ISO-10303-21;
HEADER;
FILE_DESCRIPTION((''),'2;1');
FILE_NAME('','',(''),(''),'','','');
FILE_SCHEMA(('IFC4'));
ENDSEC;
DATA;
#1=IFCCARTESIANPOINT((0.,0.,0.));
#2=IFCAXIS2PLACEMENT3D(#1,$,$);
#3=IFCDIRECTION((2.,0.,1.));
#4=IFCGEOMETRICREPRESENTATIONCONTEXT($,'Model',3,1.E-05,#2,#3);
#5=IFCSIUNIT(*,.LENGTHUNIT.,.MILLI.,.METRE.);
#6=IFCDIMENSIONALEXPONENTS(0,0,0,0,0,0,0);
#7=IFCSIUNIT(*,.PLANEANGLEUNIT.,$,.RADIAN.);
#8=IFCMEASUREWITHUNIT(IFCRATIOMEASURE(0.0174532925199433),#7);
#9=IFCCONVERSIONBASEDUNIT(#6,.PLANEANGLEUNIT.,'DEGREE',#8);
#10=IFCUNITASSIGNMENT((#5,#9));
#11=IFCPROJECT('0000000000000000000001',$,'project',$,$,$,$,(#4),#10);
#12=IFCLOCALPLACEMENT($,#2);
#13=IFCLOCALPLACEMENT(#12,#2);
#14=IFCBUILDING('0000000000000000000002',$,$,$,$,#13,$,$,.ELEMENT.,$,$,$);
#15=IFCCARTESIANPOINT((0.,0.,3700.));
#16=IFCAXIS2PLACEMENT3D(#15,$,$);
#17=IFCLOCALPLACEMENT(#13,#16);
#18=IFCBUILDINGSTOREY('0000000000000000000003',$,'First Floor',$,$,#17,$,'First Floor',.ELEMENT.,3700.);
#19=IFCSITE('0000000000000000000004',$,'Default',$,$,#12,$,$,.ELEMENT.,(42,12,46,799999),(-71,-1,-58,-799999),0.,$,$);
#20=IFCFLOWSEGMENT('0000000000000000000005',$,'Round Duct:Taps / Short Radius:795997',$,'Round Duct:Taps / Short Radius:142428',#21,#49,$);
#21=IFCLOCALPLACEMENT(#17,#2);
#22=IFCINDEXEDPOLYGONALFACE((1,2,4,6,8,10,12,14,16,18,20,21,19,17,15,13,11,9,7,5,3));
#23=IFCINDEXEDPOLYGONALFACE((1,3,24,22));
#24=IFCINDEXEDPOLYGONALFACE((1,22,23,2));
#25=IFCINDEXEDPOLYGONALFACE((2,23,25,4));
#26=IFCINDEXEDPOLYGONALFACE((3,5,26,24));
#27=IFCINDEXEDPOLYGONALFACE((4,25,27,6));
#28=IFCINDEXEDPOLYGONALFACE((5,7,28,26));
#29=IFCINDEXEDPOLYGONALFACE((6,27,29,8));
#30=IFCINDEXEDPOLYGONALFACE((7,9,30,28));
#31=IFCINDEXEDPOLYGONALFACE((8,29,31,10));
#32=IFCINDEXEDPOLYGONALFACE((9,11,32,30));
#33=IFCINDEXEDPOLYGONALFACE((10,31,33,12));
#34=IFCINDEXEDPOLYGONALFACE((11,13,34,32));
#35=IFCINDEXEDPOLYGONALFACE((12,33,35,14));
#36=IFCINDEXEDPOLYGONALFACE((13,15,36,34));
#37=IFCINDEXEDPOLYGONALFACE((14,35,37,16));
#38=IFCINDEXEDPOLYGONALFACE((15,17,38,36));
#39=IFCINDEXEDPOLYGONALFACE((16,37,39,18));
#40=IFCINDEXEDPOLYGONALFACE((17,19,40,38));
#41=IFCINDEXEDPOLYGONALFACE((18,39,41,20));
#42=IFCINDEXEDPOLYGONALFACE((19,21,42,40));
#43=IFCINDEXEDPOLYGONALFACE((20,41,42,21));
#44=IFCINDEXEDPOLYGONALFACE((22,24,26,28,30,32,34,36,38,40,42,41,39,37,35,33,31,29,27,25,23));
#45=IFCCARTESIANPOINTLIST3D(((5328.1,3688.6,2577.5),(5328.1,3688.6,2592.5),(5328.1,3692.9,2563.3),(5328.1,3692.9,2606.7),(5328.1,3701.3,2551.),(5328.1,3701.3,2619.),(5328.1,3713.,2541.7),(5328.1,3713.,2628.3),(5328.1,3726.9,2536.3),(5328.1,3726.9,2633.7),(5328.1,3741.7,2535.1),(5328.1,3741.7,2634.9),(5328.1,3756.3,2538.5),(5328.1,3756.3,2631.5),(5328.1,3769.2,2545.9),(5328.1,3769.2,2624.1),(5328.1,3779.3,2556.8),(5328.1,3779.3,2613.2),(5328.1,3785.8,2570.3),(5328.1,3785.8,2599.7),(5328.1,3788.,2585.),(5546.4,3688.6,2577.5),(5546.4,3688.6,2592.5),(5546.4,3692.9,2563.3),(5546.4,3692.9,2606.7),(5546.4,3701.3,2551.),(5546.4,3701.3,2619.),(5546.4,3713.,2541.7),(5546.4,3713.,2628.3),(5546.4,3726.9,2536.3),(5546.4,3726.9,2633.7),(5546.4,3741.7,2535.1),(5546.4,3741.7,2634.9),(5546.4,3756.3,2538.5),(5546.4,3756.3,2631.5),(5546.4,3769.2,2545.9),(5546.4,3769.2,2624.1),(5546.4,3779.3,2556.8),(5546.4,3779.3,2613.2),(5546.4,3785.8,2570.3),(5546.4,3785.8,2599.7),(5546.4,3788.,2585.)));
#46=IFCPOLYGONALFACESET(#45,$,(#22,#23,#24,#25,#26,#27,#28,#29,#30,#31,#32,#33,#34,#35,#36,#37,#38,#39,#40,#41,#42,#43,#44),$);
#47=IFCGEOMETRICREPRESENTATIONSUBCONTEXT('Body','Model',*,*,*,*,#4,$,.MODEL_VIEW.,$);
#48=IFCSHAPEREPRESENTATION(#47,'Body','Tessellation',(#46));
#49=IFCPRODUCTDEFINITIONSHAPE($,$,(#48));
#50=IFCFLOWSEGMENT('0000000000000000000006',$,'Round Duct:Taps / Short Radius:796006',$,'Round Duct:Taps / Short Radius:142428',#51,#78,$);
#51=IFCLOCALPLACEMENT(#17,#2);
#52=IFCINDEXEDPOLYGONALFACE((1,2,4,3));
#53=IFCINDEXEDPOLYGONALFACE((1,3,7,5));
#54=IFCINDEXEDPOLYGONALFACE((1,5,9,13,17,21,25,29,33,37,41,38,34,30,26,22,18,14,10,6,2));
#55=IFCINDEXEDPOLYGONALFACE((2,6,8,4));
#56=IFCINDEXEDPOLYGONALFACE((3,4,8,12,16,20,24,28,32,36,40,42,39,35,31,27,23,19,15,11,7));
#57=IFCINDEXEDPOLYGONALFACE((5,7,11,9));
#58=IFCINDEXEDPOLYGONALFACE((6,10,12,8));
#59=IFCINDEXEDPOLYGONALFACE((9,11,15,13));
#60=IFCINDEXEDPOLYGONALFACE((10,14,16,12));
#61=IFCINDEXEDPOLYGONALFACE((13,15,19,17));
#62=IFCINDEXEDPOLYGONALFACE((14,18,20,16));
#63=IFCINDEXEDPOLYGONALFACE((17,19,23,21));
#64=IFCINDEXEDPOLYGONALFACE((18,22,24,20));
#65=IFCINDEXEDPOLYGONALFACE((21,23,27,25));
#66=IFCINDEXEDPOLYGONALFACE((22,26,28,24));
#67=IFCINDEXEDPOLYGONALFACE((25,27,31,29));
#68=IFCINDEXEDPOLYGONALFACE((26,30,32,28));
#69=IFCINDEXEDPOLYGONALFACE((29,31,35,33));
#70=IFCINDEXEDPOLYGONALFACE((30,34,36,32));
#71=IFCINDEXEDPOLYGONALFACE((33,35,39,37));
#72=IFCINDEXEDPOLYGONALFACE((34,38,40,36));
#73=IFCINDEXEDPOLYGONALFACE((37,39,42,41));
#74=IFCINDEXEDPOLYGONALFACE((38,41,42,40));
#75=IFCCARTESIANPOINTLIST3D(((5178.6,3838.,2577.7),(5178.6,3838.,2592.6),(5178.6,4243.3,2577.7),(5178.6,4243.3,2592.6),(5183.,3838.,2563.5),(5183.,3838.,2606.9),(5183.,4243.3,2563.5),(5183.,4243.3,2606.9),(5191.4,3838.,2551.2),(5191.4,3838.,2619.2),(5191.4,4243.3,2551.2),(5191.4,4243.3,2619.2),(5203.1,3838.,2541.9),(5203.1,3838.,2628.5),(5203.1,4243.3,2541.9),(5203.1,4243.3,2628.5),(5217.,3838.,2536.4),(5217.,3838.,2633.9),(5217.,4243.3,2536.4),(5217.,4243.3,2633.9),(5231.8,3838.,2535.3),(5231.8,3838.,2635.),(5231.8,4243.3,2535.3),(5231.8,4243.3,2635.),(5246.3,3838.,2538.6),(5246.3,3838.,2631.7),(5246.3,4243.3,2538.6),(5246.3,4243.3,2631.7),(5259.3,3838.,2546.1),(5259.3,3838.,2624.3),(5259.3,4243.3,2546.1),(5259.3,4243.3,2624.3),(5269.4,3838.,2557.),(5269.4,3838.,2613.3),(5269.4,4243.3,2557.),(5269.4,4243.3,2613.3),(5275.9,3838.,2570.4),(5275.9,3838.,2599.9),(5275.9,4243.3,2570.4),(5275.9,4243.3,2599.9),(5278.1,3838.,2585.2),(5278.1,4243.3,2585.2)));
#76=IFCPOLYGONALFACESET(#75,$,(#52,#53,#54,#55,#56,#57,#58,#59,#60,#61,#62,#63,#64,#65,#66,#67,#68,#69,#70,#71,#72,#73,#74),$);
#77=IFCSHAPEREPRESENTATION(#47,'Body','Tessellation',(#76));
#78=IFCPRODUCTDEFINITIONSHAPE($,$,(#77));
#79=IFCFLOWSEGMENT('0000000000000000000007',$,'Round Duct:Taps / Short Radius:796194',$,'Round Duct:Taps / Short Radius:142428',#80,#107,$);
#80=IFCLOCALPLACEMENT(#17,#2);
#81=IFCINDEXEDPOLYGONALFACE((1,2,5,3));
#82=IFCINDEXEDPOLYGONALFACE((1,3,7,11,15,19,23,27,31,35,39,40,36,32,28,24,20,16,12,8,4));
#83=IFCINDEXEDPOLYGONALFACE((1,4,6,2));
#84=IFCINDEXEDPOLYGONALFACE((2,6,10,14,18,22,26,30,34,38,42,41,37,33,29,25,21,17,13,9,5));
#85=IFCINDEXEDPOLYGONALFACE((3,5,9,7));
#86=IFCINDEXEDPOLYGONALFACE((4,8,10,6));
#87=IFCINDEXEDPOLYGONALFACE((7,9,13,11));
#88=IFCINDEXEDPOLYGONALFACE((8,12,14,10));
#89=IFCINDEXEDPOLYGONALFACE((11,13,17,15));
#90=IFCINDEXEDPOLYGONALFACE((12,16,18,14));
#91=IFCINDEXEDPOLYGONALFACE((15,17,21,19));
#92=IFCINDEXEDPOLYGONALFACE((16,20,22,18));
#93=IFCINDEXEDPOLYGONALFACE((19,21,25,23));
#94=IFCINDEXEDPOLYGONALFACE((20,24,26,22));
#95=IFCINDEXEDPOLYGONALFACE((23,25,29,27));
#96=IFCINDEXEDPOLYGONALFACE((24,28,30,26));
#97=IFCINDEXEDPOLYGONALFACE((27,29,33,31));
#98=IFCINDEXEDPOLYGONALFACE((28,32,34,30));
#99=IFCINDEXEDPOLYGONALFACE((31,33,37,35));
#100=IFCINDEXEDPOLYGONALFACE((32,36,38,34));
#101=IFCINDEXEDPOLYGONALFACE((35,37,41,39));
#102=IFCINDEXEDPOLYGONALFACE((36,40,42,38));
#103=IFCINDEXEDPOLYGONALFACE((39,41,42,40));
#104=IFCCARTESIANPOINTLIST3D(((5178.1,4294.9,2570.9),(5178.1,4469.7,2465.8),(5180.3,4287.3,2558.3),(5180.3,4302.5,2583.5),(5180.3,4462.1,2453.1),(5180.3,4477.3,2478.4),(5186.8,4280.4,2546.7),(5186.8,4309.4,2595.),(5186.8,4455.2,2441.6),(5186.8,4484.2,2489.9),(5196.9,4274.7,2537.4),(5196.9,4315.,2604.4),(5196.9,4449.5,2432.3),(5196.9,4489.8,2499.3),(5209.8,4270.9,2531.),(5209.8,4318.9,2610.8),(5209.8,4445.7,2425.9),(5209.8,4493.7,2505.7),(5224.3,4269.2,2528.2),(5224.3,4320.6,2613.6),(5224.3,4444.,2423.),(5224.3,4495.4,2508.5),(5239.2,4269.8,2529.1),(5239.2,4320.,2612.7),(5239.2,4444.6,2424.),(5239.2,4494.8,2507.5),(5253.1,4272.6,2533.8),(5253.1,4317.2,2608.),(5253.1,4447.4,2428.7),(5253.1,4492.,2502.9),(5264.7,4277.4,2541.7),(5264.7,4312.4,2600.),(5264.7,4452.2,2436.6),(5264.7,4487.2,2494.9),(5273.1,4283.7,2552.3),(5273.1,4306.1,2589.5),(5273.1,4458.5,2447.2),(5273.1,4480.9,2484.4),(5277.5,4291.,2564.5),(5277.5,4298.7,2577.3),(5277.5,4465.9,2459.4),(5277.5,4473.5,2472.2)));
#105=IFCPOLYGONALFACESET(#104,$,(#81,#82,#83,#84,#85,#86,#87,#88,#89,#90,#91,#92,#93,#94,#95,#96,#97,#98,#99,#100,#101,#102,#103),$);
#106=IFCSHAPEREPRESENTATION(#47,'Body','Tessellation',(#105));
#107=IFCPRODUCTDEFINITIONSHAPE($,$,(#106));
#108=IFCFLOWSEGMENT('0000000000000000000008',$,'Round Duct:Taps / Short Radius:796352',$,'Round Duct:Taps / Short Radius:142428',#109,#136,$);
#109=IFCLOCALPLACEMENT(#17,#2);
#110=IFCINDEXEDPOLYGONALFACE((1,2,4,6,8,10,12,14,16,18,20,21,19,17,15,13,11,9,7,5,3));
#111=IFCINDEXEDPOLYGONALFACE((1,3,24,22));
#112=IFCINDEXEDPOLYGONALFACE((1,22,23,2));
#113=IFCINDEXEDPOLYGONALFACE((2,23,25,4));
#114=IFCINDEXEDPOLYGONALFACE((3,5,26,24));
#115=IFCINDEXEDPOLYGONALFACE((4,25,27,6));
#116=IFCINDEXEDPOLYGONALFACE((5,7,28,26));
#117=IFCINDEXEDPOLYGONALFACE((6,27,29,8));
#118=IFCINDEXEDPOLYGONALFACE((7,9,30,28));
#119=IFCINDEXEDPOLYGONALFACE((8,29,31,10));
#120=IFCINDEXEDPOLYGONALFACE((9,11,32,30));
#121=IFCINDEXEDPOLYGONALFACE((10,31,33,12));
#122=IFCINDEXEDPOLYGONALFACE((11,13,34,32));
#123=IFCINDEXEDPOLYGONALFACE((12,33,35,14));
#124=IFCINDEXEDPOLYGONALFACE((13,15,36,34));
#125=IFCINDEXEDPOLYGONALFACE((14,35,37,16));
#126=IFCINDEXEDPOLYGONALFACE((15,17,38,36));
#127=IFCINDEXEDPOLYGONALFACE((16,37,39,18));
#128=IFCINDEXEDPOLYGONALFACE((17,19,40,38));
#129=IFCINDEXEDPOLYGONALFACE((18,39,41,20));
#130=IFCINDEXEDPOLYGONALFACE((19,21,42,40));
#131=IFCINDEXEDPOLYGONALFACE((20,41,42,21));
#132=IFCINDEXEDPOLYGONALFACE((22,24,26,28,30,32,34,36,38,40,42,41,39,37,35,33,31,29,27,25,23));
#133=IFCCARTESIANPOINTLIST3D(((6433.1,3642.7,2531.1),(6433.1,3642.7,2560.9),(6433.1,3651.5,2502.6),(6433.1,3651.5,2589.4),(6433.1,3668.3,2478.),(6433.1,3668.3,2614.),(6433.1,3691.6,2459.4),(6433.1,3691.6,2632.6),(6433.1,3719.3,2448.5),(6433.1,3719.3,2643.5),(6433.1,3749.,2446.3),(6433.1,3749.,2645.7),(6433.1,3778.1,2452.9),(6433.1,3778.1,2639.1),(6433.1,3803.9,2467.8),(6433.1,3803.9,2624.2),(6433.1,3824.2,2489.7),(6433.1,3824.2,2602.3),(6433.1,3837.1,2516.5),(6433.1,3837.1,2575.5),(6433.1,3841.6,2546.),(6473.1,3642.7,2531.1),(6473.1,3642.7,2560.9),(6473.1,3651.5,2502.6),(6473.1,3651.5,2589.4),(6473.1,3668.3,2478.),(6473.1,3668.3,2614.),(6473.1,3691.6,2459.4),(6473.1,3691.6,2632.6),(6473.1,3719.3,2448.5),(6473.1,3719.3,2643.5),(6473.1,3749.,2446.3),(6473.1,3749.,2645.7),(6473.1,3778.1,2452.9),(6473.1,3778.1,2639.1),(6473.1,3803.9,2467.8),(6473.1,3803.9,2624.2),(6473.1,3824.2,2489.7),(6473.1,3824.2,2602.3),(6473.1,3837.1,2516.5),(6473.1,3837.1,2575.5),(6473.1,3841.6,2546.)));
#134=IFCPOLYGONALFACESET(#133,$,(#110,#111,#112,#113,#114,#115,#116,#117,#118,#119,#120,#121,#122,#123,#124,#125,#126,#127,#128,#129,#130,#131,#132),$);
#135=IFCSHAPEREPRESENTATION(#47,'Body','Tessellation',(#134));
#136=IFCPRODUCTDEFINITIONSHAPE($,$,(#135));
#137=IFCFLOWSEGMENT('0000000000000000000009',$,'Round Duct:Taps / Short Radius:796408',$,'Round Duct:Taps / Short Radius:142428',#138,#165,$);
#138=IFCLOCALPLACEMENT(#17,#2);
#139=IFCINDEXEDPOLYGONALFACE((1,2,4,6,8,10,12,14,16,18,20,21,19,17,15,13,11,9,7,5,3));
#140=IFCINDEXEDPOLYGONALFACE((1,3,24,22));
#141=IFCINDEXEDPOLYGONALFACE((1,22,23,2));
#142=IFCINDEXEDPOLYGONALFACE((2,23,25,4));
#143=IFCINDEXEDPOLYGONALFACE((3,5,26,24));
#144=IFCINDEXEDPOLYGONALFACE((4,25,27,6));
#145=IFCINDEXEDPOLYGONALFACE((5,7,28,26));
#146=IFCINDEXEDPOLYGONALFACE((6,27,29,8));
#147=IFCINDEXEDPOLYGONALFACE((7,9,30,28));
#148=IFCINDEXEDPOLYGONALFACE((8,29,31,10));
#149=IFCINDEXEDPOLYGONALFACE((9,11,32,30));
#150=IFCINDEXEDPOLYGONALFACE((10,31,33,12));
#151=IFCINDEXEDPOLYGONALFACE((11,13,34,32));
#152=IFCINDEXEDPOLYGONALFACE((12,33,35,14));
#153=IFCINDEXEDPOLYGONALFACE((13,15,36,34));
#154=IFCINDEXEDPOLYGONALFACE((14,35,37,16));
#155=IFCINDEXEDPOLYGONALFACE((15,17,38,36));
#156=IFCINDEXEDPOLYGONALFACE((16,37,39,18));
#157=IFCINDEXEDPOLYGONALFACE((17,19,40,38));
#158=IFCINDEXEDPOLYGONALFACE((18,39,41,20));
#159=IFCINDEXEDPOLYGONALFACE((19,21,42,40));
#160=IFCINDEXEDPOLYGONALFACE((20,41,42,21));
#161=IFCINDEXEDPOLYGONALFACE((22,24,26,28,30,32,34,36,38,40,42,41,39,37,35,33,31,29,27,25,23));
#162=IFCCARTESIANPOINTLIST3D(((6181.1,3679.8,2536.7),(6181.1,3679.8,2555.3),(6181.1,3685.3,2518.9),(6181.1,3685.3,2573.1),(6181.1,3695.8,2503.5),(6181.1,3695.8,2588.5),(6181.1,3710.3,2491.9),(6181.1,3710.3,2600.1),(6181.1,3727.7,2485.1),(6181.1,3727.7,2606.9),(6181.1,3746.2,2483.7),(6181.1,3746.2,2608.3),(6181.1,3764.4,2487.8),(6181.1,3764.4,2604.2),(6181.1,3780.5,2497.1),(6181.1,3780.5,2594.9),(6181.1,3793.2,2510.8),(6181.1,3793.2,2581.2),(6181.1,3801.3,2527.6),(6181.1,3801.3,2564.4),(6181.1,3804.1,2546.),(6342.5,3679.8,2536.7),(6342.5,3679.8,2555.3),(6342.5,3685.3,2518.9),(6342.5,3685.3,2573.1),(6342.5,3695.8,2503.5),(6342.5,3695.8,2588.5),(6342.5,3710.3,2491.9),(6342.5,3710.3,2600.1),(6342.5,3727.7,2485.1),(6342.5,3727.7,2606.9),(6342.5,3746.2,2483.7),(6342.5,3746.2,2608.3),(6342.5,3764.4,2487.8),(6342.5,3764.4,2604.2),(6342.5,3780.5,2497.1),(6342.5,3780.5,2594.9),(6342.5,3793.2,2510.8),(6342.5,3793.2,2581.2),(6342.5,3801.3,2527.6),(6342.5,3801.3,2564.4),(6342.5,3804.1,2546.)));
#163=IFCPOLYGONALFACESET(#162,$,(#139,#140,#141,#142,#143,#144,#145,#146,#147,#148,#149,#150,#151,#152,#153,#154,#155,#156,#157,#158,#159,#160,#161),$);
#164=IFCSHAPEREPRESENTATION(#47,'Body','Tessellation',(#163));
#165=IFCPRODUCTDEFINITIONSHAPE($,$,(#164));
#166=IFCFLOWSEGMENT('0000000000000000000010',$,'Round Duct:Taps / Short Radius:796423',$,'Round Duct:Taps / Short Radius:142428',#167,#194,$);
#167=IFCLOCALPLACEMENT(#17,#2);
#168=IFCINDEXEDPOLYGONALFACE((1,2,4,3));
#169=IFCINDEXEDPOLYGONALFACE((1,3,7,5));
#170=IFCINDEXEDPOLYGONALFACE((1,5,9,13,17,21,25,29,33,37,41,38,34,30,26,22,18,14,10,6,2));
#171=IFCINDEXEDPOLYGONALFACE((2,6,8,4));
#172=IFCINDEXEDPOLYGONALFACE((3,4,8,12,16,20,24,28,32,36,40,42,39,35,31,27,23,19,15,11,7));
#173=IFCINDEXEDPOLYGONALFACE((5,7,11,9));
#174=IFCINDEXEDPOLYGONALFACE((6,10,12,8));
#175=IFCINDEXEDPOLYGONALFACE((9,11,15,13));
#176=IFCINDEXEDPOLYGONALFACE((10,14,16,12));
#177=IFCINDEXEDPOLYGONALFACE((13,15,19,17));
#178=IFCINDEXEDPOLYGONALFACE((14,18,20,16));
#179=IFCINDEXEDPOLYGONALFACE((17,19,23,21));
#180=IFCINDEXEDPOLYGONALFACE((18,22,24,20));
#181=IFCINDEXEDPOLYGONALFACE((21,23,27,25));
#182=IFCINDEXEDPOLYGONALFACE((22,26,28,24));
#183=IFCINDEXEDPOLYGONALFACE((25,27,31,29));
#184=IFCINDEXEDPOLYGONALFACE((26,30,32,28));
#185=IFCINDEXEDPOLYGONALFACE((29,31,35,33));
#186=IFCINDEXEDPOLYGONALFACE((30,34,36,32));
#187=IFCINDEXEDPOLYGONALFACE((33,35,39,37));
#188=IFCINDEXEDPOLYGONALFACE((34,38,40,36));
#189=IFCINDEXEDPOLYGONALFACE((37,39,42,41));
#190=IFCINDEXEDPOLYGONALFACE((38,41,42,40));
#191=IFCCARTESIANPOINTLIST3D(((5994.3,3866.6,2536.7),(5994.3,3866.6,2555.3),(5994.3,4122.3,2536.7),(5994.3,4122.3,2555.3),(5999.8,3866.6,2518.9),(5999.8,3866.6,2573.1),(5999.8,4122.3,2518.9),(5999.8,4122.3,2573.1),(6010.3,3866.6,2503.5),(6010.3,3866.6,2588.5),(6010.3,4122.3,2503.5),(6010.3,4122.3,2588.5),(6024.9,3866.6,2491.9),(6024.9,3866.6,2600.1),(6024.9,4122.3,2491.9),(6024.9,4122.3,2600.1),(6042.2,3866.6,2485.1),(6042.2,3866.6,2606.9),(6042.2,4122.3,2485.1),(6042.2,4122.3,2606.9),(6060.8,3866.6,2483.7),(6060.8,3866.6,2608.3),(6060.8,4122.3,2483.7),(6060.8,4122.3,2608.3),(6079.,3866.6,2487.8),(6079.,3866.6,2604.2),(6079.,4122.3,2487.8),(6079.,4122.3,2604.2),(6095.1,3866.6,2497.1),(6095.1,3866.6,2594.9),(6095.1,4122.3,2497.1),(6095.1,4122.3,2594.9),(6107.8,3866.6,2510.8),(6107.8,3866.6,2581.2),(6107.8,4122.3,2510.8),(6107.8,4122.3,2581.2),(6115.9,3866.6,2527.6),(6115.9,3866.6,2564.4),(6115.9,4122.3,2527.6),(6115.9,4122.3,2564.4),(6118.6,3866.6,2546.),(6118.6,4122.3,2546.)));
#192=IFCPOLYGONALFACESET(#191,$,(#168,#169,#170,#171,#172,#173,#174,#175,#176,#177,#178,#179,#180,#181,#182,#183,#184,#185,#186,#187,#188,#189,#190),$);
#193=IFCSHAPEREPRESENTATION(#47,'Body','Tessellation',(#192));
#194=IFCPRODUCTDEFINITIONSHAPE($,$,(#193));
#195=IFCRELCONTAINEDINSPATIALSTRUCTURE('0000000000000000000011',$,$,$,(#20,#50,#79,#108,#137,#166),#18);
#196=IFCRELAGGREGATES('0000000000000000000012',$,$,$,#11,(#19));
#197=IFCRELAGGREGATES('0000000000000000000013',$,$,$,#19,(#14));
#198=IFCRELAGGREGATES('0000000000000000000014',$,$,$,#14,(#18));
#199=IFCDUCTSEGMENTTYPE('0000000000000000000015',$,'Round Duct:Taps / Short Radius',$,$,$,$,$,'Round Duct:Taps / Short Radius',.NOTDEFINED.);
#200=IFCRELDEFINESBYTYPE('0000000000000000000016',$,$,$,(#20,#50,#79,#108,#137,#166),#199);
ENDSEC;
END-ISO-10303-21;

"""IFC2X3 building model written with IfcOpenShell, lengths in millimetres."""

from ifc_helpers import new_model, entity, si_unit, converted_unit, direction, frame, frame_2d, origin, origin_2d_with_axis, place, context, subcontext, project, spatial, circle, extrude, type_object, element, save


model = new_model("IFC2X3")

# Units and contexts
model_context = context("Model", 3, precision=1e-05, world=origin(), true_north=direction((2.0, 0.0, 1.0)))
body_context = subcontext(model_context, "Body", "Model", "MODEL_VIEW")
ifc_project = project(units=[si_unit("LENGTHUNIT", "METRE", prefix="MILLI"), converted_unit("PLANEANGLEUNIT", "DEGREE", entity("IfcRatioMeasure", 0.0174532925199433), si_unit("PLANEANGLEUNIT", "RADIAN"), dimensions=[0, 0, 0, 0, 0, 0, 0])], contexts=[model_context])

# Site, building, storey
site_placement = place(None, origin())
site = spatial("IfcSite", under=ifc_project, at=site_placement, Name="Default", CompositionType="ELEMENT", RefLatitude=(42, 12, 46, 799999), RefLongitude=(-71, -1, -58, -799999), RefElevation=0.0)
building_placement = place(site_placement, origin())
building = spatial("IfcBuilding", under=site, at=building_placement, CompositionType="ELEMENT")
storey_placement = place(building_placement, frame((0.0, 0.0, 3700.0)))
storey = spatial("IfcBuildingStorey", under=building, at=storey_placement, Name="First Floor", LongName="First Floor", CompositionType="ELEMENT", Elevation=3700.0)

# Flow segments
duct_segment_type = type_object("IfcDuctSegmentType", Name="Round Duct:Taps / Short Radius", ElementType="Round Duct:Taps / Short Radius", PredefinedType="NOTDEFINED")
flow_segment_1_placement = place(storey_placement, origin())
element("IfcFlowSegment", 1, at=flow_segment_1_placement, inside=storey, type_object=duct_segment_type, Name="Round Duct:Taps / Short Radius:795997", ObjectType="Round Duct:Taps / Short Radius:142428", context=body_context, shape_type="SweptSolid", body=[
    extrude(circle(Radius=50.0, at=frame_2d((0.0, 0.0), x_axis=(1.0, 0.0))), frame((5328.1, 3738.0, 2585.0), z_axis=(1.0, 0.0, 0.0), x_axis=(0.0, 1.0, 0.0)), (0.0, 0.0, 1.0), 218.3),
])
flow_segment_2_placement = place(storey_placement, origin())
element("IfcFlowSegment", 2, at=flow_segment_2_placement, inside=storey, type_object=duct_segment_type, Name="Round Duct:Taps / Short Radius:796006", ObjectType="Round Duct:Taps / Short Radius:142428", context=body_context, shape_type="SweptSolid", body=[
    extrude(circle(Radius=50.0, at=origin_2d_with_axis()), frame((5228.1, 3838.0, 2585.2), z_axis=(0.0, 1.0, 0.0), x_axis=(1.0, 0.0, 0.0)), (0.0, 0.0, 1.0), 405.4),
])
flow_segment_3_placement = place(storey_placement, origin())
element("IfcFlowSegment", 3, at=flow_segment_3_placement, inside=storey, type_object=duct_segment_type, Name="Round Duct:Taps / Short Radius:796194", ObjectType="Round Duct:Taps / Short Radius:142428", context=body_context, shape_type="SweptSolid", body=[
    extrude(circle(Radius=50.0, at=frame_2d((0.0, 0.0), x_axis=(1.0, 0.0))), frame((5228.1, 4294.9, 2570.9), z_axis=(0.0, 0.857005, -0.515308), x_axis=(-1.0, 0.0, 0.0)), (0.0, 0.0, 1.0), 204.0),
])
flow_segment_4_placement = place(storey_placement, origin())
element("IfcFlowSegment", 4, at=flow_segment_4_placement, inside=storey, type_object=duct_segment_type, Name="Round Duct:Taps / Short Radius:796352", ObjectType="Round Duct:Taps / Short Radius:142428", context=body_context, shape_type="SweptSolid", body=[
    extrude(circle(Radius=100.0, at=frame_2d((0.0, 0.0), x_axis=(1.0, 0.0))), frame((6433.1, 3741.6, 2546.0), z_axis=(1.0, 0.0, 0.0), x_axis=(0.0, 1.0, 0.0)), (0.0, 0.0, 1.0), 40.0),
])
flow_segment_5_placement = place(storey_placement, origin())
element("IfcFlowSegment", 5, at=flow_segment_5_placement, inside=storey, type_object=duct_segment_type, Name="Round Duct:Taps / Short Radius:796408", ObjectType="Round Duct:Taps / Short Radius:142428", context=body_context, shape_type="SweptSolid", body=[
    extrude(circle(Radius=62.5, at=frame_2d((0.0, 0.0), x_axis=(1.0, 0.0))), frame((6181.1, 3741.6, 2546.0), z_axis=(1.0, 0.0, 0.0), x_axis=(0.0, 1.0, 0.0)), (0.0, 0.0, 1.0), 161.4),
])
flow_segment_6_placement = place(storey_placement, origin())
element("IfcFlowSegment", 6, at=flow_segment_6_placement, inside=storey, type_object=duct_segment_type, Name="Round Duct:Taps / Short Radius:796423", ObjectType="Round Duct:Taps / Short Radius:142428", context=body_context, shape_type="SweptSolid", body=[
    extrude(circle(Radius=62.5, at=origin_2d_with_axis()), frame((6056.1, 3866.6, 2546.0), z_axis=(0.0, 1.0, 0.0), x_axis=(1.0, 0.0, 0.0)), (0.0, 0.0, 1.0), 255.7),
])

save(model, "model.ifc")
